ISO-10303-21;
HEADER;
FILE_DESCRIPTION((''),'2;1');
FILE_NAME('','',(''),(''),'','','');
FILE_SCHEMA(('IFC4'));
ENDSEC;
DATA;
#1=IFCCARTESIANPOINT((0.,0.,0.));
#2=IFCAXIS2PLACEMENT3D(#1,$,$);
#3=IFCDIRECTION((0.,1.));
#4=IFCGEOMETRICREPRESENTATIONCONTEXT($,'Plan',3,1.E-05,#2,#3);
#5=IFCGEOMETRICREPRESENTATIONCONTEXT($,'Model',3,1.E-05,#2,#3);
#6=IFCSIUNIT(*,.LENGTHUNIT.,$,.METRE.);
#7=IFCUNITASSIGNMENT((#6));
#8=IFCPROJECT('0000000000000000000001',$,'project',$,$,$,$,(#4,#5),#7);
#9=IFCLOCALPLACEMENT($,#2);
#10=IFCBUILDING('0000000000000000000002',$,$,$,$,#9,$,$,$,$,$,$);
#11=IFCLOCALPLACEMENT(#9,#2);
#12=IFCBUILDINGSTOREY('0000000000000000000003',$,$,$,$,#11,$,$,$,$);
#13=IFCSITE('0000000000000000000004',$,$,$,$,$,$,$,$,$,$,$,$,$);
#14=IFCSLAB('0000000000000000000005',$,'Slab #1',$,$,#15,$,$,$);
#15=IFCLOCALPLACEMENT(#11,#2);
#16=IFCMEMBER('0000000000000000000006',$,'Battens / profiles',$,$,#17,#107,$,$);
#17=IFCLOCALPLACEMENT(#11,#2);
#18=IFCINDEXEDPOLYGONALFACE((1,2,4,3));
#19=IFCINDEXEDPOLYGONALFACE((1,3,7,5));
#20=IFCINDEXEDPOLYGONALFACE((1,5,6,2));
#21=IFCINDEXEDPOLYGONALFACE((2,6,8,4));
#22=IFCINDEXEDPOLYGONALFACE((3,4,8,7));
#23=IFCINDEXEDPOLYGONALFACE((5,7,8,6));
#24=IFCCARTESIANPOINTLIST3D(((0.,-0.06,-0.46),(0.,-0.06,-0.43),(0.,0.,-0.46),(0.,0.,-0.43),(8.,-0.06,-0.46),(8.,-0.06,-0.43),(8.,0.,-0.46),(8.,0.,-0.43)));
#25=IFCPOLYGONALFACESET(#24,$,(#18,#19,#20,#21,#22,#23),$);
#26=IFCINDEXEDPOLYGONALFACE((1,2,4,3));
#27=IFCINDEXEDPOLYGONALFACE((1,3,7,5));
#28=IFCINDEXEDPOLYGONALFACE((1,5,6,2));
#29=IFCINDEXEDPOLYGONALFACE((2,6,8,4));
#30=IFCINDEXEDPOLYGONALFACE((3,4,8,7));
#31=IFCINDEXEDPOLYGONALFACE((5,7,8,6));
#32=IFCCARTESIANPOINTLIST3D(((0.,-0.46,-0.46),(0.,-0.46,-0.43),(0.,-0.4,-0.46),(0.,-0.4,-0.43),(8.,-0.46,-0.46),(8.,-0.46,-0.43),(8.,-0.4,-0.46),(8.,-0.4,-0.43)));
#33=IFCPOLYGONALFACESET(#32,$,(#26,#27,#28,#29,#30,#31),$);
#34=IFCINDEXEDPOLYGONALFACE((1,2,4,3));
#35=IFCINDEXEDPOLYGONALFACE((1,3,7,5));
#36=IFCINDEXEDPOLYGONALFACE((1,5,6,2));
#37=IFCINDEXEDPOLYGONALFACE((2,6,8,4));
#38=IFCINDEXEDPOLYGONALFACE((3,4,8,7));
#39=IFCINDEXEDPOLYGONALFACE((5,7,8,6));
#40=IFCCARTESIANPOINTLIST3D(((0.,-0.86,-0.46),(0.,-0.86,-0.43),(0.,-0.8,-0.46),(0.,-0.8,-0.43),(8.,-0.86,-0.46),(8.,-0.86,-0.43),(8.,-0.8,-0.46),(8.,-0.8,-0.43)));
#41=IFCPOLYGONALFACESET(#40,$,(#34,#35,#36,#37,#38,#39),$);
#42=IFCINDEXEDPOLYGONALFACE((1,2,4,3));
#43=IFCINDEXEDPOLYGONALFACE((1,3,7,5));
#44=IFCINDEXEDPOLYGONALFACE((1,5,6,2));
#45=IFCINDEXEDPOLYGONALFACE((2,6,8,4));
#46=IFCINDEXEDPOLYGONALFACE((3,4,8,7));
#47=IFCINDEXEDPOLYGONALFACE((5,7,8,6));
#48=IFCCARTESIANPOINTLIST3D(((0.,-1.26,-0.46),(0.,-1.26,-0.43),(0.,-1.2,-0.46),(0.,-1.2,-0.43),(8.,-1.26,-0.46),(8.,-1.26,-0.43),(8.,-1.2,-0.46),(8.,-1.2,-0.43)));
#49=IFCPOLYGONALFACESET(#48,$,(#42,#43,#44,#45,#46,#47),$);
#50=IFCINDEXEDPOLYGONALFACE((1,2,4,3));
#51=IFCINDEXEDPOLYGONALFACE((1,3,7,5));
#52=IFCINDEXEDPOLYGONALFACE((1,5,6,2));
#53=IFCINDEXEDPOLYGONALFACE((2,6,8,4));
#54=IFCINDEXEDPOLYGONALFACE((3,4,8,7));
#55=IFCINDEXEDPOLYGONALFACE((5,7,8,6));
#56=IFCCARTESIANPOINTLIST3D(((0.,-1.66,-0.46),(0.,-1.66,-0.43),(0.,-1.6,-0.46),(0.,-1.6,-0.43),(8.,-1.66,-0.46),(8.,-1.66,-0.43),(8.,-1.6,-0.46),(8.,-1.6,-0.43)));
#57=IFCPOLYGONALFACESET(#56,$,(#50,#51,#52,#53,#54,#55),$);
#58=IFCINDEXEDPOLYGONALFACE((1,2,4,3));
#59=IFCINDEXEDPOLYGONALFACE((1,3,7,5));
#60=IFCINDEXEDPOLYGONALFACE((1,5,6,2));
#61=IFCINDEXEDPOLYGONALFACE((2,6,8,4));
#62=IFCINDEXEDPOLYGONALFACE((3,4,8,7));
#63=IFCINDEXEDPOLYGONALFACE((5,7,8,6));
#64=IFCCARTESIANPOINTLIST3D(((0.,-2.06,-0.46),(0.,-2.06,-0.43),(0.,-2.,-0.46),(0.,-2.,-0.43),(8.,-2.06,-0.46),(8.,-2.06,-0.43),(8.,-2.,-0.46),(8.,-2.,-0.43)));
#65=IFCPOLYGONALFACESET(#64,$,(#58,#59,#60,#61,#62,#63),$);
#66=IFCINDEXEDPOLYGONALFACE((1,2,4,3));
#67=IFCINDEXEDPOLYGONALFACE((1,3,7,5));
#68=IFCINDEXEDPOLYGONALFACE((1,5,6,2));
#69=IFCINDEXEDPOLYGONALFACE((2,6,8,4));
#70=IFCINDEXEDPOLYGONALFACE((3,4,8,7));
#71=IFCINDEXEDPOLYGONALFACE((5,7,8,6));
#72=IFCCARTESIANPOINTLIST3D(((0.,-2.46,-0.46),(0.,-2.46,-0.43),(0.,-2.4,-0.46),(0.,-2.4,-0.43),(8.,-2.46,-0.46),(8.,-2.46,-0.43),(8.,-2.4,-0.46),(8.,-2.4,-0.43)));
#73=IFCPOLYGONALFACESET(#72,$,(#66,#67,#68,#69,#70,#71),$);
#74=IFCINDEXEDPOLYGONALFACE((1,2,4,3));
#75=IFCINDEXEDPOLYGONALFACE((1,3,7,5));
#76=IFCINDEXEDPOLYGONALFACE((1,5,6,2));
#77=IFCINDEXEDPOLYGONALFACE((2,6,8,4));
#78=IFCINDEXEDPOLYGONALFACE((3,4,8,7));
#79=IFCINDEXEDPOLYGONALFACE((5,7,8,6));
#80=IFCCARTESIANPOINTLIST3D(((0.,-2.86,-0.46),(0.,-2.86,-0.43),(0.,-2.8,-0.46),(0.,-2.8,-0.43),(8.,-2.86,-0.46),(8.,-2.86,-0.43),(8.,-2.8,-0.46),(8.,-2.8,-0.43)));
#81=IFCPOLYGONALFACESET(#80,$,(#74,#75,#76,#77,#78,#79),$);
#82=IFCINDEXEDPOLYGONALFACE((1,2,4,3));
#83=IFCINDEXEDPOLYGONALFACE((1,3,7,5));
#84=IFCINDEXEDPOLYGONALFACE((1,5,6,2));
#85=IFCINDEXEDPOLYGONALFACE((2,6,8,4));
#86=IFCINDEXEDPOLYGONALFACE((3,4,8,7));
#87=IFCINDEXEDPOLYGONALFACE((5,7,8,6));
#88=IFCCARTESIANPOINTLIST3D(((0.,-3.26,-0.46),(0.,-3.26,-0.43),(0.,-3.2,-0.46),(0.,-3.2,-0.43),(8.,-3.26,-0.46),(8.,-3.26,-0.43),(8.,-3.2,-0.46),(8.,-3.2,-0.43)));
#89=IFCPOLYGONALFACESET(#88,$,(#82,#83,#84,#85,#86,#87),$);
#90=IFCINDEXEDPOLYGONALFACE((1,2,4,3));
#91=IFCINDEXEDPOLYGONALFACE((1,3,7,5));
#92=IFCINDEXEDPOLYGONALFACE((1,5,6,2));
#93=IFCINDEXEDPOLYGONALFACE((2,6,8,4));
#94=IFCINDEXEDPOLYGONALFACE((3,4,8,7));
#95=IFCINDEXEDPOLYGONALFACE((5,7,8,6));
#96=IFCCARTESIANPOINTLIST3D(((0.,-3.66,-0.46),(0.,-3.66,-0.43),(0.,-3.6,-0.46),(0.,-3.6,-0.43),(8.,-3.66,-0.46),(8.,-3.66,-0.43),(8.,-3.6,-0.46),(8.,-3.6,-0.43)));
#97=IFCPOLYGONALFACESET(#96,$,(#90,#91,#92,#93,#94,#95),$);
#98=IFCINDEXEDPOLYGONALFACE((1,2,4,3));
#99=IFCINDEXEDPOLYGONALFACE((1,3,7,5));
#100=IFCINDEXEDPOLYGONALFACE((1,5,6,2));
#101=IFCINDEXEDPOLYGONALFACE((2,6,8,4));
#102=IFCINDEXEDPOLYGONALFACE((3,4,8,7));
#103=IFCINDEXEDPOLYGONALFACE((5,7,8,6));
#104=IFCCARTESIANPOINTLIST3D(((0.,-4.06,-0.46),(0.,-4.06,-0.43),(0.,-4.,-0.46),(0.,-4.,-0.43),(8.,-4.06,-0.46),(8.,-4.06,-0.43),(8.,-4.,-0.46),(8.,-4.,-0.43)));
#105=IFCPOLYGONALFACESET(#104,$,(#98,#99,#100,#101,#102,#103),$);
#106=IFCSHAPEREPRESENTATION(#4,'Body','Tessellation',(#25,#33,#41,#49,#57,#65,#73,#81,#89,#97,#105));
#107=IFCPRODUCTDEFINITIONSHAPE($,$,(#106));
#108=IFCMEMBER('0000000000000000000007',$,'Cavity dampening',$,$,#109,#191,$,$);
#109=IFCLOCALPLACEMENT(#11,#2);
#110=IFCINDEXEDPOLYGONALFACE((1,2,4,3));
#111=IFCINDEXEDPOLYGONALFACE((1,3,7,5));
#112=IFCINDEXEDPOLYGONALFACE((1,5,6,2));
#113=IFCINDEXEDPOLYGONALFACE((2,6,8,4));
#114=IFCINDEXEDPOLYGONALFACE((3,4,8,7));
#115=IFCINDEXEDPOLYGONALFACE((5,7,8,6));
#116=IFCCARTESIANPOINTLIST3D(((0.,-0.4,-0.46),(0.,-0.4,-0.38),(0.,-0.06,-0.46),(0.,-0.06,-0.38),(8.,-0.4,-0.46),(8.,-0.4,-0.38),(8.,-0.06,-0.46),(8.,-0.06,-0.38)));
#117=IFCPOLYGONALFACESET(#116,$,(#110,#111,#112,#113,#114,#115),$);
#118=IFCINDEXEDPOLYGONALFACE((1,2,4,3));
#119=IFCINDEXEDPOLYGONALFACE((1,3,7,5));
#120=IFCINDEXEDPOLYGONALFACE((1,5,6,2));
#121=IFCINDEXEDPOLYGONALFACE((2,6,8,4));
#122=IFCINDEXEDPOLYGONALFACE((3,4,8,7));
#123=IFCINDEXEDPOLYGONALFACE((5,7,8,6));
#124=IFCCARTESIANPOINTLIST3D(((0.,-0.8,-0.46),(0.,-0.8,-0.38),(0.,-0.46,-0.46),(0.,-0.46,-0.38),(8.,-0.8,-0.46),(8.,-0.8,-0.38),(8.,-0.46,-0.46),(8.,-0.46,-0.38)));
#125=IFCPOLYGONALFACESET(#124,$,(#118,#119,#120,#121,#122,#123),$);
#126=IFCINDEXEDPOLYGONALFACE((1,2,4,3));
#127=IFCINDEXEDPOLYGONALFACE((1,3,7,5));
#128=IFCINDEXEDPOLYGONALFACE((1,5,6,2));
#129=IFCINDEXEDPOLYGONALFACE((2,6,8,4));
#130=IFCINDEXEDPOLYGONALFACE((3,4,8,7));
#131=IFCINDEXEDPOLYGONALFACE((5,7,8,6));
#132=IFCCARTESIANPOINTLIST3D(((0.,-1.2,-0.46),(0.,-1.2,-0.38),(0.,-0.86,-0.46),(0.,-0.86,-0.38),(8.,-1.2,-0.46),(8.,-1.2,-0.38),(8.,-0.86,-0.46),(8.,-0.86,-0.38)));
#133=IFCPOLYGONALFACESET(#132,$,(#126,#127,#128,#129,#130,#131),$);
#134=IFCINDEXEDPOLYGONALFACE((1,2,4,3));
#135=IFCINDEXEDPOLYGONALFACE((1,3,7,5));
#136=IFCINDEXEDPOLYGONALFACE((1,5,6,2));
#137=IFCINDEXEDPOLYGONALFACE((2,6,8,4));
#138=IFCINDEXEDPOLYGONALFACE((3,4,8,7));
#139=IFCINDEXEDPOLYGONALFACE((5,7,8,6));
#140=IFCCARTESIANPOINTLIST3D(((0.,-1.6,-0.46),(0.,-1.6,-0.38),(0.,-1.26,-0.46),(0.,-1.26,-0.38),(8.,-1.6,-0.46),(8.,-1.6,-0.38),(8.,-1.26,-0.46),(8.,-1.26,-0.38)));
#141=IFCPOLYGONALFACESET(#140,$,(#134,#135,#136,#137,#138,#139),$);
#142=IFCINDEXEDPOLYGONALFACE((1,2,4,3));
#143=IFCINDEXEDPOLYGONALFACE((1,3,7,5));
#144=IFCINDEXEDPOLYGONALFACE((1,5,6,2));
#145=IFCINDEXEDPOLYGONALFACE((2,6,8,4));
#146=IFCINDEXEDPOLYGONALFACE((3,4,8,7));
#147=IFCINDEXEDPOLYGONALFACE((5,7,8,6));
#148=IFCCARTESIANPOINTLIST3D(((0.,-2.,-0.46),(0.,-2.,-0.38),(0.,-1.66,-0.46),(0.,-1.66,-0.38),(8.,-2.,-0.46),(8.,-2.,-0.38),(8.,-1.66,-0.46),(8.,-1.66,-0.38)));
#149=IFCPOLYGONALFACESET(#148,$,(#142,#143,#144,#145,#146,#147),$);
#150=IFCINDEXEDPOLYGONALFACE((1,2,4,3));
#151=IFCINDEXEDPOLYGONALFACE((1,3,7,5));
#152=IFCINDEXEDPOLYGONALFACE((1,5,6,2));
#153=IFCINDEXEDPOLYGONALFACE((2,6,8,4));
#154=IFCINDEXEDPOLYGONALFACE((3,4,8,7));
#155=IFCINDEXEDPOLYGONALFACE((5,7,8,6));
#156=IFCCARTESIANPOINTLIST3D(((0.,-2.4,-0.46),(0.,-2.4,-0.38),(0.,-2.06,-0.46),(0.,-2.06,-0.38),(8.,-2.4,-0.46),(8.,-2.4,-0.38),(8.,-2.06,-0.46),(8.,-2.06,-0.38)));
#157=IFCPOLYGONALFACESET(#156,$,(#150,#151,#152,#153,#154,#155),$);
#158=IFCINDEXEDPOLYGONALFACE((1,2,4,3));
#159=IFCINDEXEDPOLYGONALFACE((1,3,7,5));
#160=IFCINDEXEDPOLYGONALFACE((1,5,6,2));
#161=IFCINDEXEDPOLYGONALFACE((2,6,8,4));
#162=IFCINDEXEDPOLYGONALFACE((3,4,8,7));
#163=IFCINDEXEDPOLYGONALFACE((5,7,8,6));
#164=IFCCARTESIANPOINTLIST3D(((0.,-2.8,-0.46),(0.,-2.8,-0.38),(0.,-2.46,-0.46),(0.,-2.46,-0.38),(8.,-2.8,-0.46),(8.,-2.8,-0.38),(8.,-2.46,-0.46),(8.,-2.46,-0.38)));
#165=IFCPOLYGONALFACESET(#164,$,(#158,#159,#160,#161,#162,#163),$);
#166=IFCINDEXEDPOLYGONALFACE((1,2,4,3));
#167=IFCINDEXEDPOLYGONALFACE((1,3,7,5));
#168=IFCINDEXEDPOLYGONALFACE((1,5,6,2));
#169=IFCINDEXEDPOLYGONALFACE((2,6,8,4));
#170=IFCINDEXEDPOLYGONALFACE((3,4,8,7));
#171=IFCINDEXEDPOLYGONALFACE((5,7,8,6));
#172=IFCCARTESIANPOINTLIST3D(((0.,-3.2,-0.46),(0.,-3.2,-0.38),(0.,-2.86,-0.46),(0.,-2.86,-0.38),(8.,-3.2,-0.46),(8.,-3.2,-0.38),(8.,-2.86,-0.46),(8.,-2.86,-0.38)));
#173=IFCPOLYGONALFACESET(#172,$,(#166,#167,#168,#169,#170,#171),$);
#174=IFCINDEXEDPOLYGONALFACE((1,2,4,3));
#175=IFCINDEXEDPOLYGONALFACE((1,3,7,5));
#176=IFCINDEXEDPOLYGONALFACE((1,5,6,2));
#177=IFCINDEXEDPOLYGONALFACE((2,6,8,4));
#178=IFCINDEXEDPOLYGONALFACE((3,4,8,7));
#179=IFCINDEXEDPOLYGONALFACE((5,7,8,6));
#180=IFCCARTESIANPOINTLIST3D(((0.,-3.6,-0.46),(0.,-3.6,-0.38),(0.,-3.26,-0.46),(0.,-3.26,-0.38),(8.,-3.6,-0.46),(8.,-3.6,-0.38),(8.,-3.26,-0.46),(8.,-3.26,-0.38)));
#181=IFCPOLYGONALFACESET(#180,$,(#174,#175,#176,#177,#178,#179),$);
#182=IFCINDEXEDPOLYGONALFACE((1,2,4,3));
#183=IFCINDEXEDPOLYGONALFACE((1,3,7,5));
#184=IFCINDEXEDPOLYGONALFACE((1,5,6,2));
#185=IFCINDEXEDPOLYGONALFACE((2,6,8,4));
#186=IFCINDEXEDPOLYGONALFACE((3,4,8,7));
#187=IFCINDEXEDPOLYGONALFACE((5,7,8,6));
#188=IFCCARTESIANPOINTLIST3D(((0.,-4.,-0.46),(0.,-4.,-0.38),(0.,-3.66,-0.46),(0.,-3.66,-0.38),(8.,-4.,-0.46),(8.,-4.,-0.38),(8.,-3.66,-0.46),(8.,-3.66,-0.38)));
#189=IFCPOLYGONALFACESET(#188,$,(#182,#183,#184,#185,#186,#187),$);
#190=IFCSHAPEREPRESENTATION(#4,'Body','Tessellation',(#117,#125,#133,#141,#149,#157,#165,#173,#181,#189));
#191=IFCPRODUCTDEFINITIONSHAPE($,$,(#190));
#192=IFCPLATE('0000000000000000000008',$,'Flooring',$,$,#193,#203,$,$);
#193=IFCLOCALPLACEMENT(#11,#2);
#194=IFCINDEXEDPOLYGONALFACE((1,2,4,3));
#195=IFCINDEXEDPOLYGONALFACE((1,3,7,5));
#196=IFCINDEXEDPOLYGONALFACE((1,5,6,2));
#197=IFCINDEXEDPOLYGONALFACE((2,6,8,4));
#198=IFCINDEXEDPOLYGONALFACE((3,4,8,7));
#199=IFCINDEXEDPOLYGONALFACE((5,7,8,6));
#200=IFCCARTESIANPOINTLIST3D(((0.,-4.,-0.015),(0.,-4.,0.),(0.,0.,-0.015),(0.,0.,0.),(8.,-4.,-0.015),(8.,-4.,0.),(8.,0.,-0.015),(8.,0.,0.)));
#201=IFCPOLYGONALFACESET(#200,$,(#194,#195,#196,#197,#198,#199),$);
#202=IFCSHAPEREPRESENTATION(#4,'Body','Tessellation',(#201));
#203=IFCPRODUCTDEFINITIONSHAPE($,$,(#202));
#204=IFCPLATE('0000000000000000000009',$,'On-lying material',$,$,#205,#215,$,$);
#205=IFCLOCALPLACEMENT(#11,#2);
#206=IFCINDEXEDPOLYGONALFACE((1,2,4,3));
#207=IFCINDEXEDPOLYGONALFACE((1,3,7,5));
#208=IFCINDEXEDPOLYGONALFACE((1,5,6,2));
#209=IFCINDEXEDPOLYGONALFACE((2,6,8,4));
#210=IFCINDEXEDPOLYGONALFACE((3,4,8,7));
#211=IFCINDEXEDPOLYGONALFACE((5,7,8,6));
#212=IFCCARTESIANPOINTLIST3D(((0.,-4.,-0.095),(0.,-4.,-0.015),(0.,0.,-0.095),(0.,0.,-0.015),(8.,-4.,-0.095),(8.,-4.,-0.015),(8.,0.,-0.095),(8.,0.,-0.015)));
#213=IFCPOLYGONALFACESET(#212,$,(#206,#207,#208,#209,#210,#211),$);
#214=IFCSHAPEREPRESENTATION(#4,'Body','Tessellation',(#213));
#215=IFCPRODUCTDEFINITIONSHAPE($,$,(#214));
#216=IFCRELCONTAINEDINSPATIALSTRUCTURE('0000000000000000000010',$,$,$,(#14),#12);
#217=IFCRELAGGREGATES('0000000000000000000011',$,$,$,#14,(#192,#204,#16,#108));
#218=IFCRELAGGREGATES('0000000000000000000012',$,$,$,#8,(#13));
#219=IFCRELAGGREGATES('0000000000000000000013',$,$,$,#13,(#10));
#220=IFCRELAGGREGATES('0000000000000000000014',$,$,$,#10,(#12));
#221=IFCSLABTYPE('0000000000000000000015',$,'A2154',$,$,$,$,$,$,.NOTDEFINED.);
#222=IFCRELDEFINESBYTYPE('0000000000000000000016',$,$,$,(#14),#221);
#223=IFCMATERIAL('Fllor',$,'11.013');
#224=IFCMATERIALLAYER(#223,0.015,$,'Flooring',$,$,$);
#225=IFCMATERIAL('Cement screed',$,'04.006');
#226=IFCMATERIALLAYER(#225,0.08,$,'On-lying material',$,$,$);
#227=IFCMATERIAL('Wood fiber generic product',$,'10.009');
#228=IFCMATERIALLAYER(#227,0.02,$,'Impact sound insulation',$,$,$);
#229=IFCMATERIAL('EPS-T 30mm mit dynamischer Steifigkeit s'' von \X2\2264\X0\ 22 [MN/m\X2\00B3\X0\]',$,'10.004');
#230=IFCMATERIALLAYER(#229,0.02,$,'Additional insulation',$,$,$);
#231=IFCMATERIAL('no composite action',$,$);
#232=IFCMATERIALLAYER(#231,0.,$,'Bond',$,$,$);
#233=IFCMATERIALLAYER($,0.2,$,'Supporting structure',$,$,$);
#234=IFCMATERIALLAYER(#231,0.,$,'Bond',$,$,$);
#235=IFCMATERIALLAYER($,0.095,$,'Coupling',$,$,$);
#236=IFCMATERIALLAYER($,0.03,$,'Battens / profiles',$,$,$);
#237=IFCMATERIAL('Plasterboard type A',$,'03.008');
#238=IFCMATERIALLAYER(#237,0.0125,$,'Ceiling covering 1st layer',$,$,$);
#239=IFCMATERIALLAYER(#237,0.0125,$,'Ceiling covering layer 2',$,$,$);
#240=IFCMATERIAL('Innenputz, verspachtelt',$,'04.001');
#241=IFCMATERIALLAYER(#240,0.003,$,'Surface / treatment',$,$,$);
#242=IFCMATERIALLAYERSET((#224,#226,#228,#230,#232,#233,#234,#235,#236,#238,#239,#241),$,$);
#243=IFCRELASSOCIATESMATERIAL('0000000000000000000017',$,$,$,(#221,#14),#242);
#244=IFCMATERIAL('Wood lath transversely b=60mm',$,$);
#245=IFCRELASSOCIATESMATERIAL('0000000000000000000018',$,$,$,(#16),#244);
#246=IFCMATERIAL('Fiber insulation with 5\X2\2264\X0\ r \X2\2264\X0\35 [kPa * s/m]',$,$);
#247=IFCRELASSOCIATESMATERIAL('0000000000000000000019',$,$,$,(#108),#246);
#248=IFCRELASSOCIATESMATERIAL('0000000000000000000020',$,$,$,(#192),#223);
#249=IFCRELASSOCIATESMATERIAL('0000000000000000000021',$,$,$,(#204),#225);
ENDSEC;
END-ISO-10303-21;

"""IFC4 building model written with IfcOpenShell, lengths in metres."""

from ifc_helpers import new_model, si_unit, direction, frame, frame_2d, origin, origin_with_axes, place, context, project, spatial, rectangle, extrude, material, layer, layer_set, type_object, element, aggregate, save


model = new_model("IFC4")

# Units and contexts
plan_context = context("Plan", 3, precision=1e-05, world=origin(), true_north=direction((0.0, 1.0)))
model_context = context("Model", 3, precision=1e-05, world=origin(), true_north=direction((0.0, 1.0)))
ifc_project = project(units=[si_unit("LENGTHUNIT", "METRE")], contexts=[plan_context, model_context])

# Site, building, storey
site = spatial("IfcSite", under=ifc_project)
building_placement = place(None, origin())
building = spatial("IfcBuilding", under=site, at=building_placement)
storey_placement = place(building_placement, origin())
storey = spatial("IfcBuildingStorey", under=building, at=storey_placement)

# Slab, members, plates
ifc_material_1 = material(Name="Fllor", Category="11.013")
ifc_layer_1 = layer(ifc_material_1, 0.015, Name="Flooring")
ifc_material_2 = material(Name="Cement screed", Category="04.006")
ifc_layer_2 = layer(ifc_material_2, 0.08, Name="On-lying material")
ifc_material_3 = material(Name="Wood fiber generic product", Category="10.009")
ifc_layer_3 = layer(ifc_material_3, 0.02, Name="Impact sound insulation")
ifc_material_4 = material(Name="EPS-T 30mm mit dynamischer Steifigkeit s' von ≤ 22 [MN/m³]", Category="10.004")
ifc_layer_4 = layer(ifc_material_4, 0.02, Name="Additional insulation")
ifc_material_5 = material(Name="no composite action")
ifc_layer_5 = layer(ifc_material_5, 0.0, Name="Bond")
ifc_layer_6 = layer(None, 0.2, Name="Supporting structure")
ifc_layer_7 = layer(ifc_material_5, 0.0, Name="Bond")
ifc_layer_8 = layer(None, 0.095, Name="Coupling")
ifc_layer_9 = layer(None, 0.03, Name="Battens / profiles")
ifc_material_6 = material(Name="Plasterboard type A", Category="03.008")
ifc_layer_10 = layer(ifc_material_6, 0.0125, Name="Ceiling covering 1st layer")
ifc_layer_11 = layer(ifc_material_6, 0.0125, Name="Ceiling covering layer 2")
ifc_material_7 = material(Name="Innenputz, verspachtelt", Category="04.001")
ifc_layer_12 = layer(ifc_material_7, 0.003, Name="Surface / treatment")
ifc_layer_set = layer_set([ifc_layer_1, ifc_layer_2, ifc_layer_3, ifc_layer_4, ifc_layer_5, ifc_layer_6, ifc_layer_7, ifc_layer_8, ifc_layer_9, ifc_layer_10, ifc_layer_11, ifc_layer_12])
slab_type = type_object("IfcSlabType", Name="A2154", PredefinedType="NOTDEFINED", material=ifc_layer_set)
slab_placement = place(None, frame((0.0, 0.0, 0.0), z_axis=(0.0, 0.0, -1.0), x_axis=(1.0, 0.0, 0.0)))
slab = element("IfcSlab", 1, at=slab_placement, inside=storey, type_object=slab_type, material=ifc_layer_set, Name="Slab #1")
ifc_material_8 = material(Name="Wood lath transversely b=60mm")
member_1_placement = place(slab_placement, origin())
member_1 = element("IfcMember", 2, at=member_1_placement, material=ifc_material_8, Name="Battens / profiles", context=plan_context, shape_type="SweptSolid", body=[
    extrude(rectangle(XDim=0.06, YDim=0.03, at=frame_2d((0.03, 0.015), x_axis=(1.0, 0.0))), frame((0.0, 0.0, 0.43), z_axis=(1.0, 0.0, 0.0), x_axis=(0.0, 1.0, 0.0)), (0.0, 0.0, 1.0), 8.0),
    extrude(rectangle(XDim=0.06, YDim=0.03, at=frame_2d((0.03, 0.015), x_axis=(1.0, 0.0))), frame((0.0, 0.4, 0.43), z_axis=(1.0, 0.0, 0.0), x_axis=(0.0, 1.0, 0.0)), (0.0, 0.0, 1.0), 8.0),
    extrude(rectangle(XDim=0.06, YDim=0.03, at=frame_2d((0.03, 0.015), x_axis=(1.0, 0.0))), frame((0.0, 0.8, 0.43), z_axis=(1.0, 0.0, 0.0), x_axis=(0.0, 1.0, 0.0)), (0.0, 0.0, 1.0), 8.0),
    extrude(rectangle(XDim=0.06, YDim=0.03, at=frame_2d((0.03, 0.015), x_axis=(1.0, 0.0))), frame((0.0, 1.2, 0.43), z_axis=(1.0, 0.0, 0.0), x_axis=(0.0, 1.0, 0.0)), (0.0, 0.0, 1.0), 8.0),
    extrude(rectangle(XDim=0.06, YDim=0.03, at=frame_2d((0.03, 0.015), x_axis=(1.0, 0.0))), frame((0.0, 1.6, 0.43), z_axis=(1.0, 0.0, 0.0), x_axis=(0.0, 1.0, 0.0)), (0.0, 0.0, 1.0), 8.0),
    extrude(rectangle(XDim=0.06, YDim=0.03, at=frame_2d((0.03, 0.015), x_axis=(1.0, 0.0))), frame((0.0, 2.0, 0.43), z_axis=(1.0, 0.0, 0.0), x_axis=(0.0, 1.0, 0.0)), (0.0, 0.0, 1.0), 8.0),
    extrude(rectangle(XDim=0.06, YDim=0.03, at=frame_2d((0.03, 0.015), x_axis=(1.0, 0.0))), frame((0.0, 2.4, 0.43), z_axis=(1.0, 0.0, 0.0), x_axis=(0.0, 1.0, 0.0)), (0.0, 0.0, 1.0), 8.0),
    extrude(rectangle(XDim=0.06, YDim=0.03, at=frame_2d((0.03, 0.015), x_axis=(1.0, 0.0))), frame((0.0, 2.8, 0.43), z_axis=(1.0, 0.0, 0.0), x_axis=(0.0, 1.0, 0.0)), (0.0, 0.0, 1.0), 8.0),
    extrude(rectangle(XDim=0.06, YDim=0.03, at=frame_2d((0.03, 0.015), x_axis=(1.0, 0.0))), frame((0.0, 3.2, 0.43), z_axis=(1.0, 0.0, 0.0), x_axis=(0.0, 1.0, 0.0)), (0.0, 0.0, 1.0), 8.0),
    extrude(rectangle(XDim=0.06, YDim=0.03, at=frame_2d((0.03, 0.015), x_axis=(1.0, 0.0))), frame((0.0, 3.6, 0.43), z_axis=(1.0, 0.0, 0.0), x_axis=(0.0, 1.0, 0.0)), (0.0, 0.0, 1.0), 8.0),
    extrude(rectangle(XDim=0.06, YDim=0.03, at=frame_2d((0.03, 0.015), x_axis=(1.0, 0.0))), frame((0.0, 4.0, 0.43), z_axis=(1.0, 0.0, 0.0), x_axis=(0.0, 1.0, 0.0)), (0.0, 0.0, 1.0), 8.0),
])
ifc_material_9 = material(Name="Fiber insulation with 5≤ r ≤35 [kPa * s/m]")
member_2_placement = place(slab_placement, origin())
member_2 = element("IfcMember", 3, at=member_2_placement, material=ifc_material_9, Name="Cavity dampening", context=plan_context, shape_type="SweptSolid", body=[
    extrude(rectangle(XDim=0.34, YDim=0.08, at=frame_2d((0.17, 0.04), x_axis=(1.0, 0.0))), frame((0.0, 0.06, 0.38), z_axis=(1.0, 0.0, 0.0), x_axis=(0.0, 1.0, 0.0)), (0.0, 0.0, 1.0), 8.0),
    extrude(rectangle(XDim=0.34, YDim=0.08, at=frame_2d((0.17, 0.04), x_axis=(1.0, 0.0))), frame((0.0, 0.46, 0.38), z_axis=(1.0, 0.0, 0.0), x_axis=(0.0, 1.0, 0.0)), (0.0, 0.0, 1.0), 8.0),
    extrude(rectangle(XDim=0.34, YDim=0.08, at=frame_2d((0.17, 0.04), x_axis=(1.0, 0.0))), frame((0.0, 0.86, 0.38), z_axis=(1.0, 0.0, 0.0), x_axis=(0.0, 1.0, 0.0)), (0.0, 0.0, 1.0), 8.0),
    extrude(rectangle(XDim=0.34, YDim=0.08, at=frame_2d((0.17, 0.04), x_axis=(1.0, 0.0))), frame((0.0, 1.26, 0.38), z_axis=(1.0, 0.0, 0.0), x_axis=(0.0, 1.0, 0.0)), (0.0, 0.0, 1.0), 8.0),
    extrude(rectangle(XDim=0.34, YDim=0.08, at=frame_2d((0.17, 0.04), x_axis=(1.0, 0.0))), frame((0.0, 1.66, 0.38), z_axis=(1.0, 0.0, 0.0), x_axis=(0.0, 1.0, 0.0)), (0.0, 0.0, 1.0), 8.0),
    extrude(rectangle(XDim=0.34, YDim=0.08, at=frame_2d((0.17, 0.04), x_axis=(1.0, 0.0))), frame((0.0, 2.06, 0.38), z_axis=(1.0, 0.0, 0.0), x_axis=(0.0, 1.0, 0.0)), (0.0, 0.0, 1.0), 8.0),
    extrude(rectangle(XDim=0.34, YDim=0.08, at=frame_2d((0.17, 0.04), x_axis=(1.0, 0.0))), frame((0.0, 2.46, 0.38), z_axis=(1.0, 0.0, 0.0), x_axis=(0.0, 1.0, 0.0)), (0.0, 0.0, 1.0), 8.0),
    extrude(rectangle(XDim=0.34, YDim=0.08, at=frame_2d((0.17, 0.04), x_axis=(1.0, 0.0))), frame((0.0, 2.86, 0.38), z_axis=(1.0, 0.0, 0.0), x_axis=(0.0, 1.0, 0.0)), (0.0, 0.0, 1.0), 8.0),
    extrude(rectangle(XDim=0.34, YDim=0.08, at=frame_2d((0.17, 0.04), x_axis=(1.0, 0.0))), frame((0.0, 3.26, 0.38), z_axis=(1.0, 0.0, 0.0), x_axis=(0.0, 1.0, 0.0)), (0.0, 0.0, 1.0), 8.0),
    extrude(rectangle(XDim=0.34, YDim=0.08, at=frame_2d((0.17, 0.04), x_axis=(1.0, 0.0))), frame((0.0, 3.66, 0.38), z_axis=(1.0, 0.0, 0.0), x_axis=(0.0, 1.0, 0.0)), (0.0, 0.0, 1.0), 8.0),
])
plate_1_placement = place(slab_placement, origin())
plate_1 = element("IfcPlate", 4, at=plate_1_placement, material=ifc_material_1, Name="Flooring", context=plan_context, shape_type="SweptSolid", body=[
    extrude(rectangle(XDim=8.0, YDim=4.0, at=frame_2d((4.0, 2.0), x_axis=(1.0, 0.0))), origin_with_axes(), (0.0, 0.0, 1.0), 0.015),
])
plate_2_placement = place(slab_placement, origin())
plate_2 = element("IfcPlate", 5, at=plate_2_placement, material=ifc_material_2, Name="On-lying material", context=plan_context, shape_type="SweptSolid", body=[
    extrude(rectangle(XDim=8.0, YDim=4.0, at=frame_2d((4.0, 2.0), x_axis=(1.0, 0.0))), frame((0.0, 0.0, 0.015), z_axis=(0.0, 0.0, 1.0), x_axis=(1.0, 0.0, 0.0)), (0.0, 0.0, 1.0), 0.08),
])
aggregate(slab, [plate_1, plate_2, member_1, member_2])

save(model, "model.ifc")
